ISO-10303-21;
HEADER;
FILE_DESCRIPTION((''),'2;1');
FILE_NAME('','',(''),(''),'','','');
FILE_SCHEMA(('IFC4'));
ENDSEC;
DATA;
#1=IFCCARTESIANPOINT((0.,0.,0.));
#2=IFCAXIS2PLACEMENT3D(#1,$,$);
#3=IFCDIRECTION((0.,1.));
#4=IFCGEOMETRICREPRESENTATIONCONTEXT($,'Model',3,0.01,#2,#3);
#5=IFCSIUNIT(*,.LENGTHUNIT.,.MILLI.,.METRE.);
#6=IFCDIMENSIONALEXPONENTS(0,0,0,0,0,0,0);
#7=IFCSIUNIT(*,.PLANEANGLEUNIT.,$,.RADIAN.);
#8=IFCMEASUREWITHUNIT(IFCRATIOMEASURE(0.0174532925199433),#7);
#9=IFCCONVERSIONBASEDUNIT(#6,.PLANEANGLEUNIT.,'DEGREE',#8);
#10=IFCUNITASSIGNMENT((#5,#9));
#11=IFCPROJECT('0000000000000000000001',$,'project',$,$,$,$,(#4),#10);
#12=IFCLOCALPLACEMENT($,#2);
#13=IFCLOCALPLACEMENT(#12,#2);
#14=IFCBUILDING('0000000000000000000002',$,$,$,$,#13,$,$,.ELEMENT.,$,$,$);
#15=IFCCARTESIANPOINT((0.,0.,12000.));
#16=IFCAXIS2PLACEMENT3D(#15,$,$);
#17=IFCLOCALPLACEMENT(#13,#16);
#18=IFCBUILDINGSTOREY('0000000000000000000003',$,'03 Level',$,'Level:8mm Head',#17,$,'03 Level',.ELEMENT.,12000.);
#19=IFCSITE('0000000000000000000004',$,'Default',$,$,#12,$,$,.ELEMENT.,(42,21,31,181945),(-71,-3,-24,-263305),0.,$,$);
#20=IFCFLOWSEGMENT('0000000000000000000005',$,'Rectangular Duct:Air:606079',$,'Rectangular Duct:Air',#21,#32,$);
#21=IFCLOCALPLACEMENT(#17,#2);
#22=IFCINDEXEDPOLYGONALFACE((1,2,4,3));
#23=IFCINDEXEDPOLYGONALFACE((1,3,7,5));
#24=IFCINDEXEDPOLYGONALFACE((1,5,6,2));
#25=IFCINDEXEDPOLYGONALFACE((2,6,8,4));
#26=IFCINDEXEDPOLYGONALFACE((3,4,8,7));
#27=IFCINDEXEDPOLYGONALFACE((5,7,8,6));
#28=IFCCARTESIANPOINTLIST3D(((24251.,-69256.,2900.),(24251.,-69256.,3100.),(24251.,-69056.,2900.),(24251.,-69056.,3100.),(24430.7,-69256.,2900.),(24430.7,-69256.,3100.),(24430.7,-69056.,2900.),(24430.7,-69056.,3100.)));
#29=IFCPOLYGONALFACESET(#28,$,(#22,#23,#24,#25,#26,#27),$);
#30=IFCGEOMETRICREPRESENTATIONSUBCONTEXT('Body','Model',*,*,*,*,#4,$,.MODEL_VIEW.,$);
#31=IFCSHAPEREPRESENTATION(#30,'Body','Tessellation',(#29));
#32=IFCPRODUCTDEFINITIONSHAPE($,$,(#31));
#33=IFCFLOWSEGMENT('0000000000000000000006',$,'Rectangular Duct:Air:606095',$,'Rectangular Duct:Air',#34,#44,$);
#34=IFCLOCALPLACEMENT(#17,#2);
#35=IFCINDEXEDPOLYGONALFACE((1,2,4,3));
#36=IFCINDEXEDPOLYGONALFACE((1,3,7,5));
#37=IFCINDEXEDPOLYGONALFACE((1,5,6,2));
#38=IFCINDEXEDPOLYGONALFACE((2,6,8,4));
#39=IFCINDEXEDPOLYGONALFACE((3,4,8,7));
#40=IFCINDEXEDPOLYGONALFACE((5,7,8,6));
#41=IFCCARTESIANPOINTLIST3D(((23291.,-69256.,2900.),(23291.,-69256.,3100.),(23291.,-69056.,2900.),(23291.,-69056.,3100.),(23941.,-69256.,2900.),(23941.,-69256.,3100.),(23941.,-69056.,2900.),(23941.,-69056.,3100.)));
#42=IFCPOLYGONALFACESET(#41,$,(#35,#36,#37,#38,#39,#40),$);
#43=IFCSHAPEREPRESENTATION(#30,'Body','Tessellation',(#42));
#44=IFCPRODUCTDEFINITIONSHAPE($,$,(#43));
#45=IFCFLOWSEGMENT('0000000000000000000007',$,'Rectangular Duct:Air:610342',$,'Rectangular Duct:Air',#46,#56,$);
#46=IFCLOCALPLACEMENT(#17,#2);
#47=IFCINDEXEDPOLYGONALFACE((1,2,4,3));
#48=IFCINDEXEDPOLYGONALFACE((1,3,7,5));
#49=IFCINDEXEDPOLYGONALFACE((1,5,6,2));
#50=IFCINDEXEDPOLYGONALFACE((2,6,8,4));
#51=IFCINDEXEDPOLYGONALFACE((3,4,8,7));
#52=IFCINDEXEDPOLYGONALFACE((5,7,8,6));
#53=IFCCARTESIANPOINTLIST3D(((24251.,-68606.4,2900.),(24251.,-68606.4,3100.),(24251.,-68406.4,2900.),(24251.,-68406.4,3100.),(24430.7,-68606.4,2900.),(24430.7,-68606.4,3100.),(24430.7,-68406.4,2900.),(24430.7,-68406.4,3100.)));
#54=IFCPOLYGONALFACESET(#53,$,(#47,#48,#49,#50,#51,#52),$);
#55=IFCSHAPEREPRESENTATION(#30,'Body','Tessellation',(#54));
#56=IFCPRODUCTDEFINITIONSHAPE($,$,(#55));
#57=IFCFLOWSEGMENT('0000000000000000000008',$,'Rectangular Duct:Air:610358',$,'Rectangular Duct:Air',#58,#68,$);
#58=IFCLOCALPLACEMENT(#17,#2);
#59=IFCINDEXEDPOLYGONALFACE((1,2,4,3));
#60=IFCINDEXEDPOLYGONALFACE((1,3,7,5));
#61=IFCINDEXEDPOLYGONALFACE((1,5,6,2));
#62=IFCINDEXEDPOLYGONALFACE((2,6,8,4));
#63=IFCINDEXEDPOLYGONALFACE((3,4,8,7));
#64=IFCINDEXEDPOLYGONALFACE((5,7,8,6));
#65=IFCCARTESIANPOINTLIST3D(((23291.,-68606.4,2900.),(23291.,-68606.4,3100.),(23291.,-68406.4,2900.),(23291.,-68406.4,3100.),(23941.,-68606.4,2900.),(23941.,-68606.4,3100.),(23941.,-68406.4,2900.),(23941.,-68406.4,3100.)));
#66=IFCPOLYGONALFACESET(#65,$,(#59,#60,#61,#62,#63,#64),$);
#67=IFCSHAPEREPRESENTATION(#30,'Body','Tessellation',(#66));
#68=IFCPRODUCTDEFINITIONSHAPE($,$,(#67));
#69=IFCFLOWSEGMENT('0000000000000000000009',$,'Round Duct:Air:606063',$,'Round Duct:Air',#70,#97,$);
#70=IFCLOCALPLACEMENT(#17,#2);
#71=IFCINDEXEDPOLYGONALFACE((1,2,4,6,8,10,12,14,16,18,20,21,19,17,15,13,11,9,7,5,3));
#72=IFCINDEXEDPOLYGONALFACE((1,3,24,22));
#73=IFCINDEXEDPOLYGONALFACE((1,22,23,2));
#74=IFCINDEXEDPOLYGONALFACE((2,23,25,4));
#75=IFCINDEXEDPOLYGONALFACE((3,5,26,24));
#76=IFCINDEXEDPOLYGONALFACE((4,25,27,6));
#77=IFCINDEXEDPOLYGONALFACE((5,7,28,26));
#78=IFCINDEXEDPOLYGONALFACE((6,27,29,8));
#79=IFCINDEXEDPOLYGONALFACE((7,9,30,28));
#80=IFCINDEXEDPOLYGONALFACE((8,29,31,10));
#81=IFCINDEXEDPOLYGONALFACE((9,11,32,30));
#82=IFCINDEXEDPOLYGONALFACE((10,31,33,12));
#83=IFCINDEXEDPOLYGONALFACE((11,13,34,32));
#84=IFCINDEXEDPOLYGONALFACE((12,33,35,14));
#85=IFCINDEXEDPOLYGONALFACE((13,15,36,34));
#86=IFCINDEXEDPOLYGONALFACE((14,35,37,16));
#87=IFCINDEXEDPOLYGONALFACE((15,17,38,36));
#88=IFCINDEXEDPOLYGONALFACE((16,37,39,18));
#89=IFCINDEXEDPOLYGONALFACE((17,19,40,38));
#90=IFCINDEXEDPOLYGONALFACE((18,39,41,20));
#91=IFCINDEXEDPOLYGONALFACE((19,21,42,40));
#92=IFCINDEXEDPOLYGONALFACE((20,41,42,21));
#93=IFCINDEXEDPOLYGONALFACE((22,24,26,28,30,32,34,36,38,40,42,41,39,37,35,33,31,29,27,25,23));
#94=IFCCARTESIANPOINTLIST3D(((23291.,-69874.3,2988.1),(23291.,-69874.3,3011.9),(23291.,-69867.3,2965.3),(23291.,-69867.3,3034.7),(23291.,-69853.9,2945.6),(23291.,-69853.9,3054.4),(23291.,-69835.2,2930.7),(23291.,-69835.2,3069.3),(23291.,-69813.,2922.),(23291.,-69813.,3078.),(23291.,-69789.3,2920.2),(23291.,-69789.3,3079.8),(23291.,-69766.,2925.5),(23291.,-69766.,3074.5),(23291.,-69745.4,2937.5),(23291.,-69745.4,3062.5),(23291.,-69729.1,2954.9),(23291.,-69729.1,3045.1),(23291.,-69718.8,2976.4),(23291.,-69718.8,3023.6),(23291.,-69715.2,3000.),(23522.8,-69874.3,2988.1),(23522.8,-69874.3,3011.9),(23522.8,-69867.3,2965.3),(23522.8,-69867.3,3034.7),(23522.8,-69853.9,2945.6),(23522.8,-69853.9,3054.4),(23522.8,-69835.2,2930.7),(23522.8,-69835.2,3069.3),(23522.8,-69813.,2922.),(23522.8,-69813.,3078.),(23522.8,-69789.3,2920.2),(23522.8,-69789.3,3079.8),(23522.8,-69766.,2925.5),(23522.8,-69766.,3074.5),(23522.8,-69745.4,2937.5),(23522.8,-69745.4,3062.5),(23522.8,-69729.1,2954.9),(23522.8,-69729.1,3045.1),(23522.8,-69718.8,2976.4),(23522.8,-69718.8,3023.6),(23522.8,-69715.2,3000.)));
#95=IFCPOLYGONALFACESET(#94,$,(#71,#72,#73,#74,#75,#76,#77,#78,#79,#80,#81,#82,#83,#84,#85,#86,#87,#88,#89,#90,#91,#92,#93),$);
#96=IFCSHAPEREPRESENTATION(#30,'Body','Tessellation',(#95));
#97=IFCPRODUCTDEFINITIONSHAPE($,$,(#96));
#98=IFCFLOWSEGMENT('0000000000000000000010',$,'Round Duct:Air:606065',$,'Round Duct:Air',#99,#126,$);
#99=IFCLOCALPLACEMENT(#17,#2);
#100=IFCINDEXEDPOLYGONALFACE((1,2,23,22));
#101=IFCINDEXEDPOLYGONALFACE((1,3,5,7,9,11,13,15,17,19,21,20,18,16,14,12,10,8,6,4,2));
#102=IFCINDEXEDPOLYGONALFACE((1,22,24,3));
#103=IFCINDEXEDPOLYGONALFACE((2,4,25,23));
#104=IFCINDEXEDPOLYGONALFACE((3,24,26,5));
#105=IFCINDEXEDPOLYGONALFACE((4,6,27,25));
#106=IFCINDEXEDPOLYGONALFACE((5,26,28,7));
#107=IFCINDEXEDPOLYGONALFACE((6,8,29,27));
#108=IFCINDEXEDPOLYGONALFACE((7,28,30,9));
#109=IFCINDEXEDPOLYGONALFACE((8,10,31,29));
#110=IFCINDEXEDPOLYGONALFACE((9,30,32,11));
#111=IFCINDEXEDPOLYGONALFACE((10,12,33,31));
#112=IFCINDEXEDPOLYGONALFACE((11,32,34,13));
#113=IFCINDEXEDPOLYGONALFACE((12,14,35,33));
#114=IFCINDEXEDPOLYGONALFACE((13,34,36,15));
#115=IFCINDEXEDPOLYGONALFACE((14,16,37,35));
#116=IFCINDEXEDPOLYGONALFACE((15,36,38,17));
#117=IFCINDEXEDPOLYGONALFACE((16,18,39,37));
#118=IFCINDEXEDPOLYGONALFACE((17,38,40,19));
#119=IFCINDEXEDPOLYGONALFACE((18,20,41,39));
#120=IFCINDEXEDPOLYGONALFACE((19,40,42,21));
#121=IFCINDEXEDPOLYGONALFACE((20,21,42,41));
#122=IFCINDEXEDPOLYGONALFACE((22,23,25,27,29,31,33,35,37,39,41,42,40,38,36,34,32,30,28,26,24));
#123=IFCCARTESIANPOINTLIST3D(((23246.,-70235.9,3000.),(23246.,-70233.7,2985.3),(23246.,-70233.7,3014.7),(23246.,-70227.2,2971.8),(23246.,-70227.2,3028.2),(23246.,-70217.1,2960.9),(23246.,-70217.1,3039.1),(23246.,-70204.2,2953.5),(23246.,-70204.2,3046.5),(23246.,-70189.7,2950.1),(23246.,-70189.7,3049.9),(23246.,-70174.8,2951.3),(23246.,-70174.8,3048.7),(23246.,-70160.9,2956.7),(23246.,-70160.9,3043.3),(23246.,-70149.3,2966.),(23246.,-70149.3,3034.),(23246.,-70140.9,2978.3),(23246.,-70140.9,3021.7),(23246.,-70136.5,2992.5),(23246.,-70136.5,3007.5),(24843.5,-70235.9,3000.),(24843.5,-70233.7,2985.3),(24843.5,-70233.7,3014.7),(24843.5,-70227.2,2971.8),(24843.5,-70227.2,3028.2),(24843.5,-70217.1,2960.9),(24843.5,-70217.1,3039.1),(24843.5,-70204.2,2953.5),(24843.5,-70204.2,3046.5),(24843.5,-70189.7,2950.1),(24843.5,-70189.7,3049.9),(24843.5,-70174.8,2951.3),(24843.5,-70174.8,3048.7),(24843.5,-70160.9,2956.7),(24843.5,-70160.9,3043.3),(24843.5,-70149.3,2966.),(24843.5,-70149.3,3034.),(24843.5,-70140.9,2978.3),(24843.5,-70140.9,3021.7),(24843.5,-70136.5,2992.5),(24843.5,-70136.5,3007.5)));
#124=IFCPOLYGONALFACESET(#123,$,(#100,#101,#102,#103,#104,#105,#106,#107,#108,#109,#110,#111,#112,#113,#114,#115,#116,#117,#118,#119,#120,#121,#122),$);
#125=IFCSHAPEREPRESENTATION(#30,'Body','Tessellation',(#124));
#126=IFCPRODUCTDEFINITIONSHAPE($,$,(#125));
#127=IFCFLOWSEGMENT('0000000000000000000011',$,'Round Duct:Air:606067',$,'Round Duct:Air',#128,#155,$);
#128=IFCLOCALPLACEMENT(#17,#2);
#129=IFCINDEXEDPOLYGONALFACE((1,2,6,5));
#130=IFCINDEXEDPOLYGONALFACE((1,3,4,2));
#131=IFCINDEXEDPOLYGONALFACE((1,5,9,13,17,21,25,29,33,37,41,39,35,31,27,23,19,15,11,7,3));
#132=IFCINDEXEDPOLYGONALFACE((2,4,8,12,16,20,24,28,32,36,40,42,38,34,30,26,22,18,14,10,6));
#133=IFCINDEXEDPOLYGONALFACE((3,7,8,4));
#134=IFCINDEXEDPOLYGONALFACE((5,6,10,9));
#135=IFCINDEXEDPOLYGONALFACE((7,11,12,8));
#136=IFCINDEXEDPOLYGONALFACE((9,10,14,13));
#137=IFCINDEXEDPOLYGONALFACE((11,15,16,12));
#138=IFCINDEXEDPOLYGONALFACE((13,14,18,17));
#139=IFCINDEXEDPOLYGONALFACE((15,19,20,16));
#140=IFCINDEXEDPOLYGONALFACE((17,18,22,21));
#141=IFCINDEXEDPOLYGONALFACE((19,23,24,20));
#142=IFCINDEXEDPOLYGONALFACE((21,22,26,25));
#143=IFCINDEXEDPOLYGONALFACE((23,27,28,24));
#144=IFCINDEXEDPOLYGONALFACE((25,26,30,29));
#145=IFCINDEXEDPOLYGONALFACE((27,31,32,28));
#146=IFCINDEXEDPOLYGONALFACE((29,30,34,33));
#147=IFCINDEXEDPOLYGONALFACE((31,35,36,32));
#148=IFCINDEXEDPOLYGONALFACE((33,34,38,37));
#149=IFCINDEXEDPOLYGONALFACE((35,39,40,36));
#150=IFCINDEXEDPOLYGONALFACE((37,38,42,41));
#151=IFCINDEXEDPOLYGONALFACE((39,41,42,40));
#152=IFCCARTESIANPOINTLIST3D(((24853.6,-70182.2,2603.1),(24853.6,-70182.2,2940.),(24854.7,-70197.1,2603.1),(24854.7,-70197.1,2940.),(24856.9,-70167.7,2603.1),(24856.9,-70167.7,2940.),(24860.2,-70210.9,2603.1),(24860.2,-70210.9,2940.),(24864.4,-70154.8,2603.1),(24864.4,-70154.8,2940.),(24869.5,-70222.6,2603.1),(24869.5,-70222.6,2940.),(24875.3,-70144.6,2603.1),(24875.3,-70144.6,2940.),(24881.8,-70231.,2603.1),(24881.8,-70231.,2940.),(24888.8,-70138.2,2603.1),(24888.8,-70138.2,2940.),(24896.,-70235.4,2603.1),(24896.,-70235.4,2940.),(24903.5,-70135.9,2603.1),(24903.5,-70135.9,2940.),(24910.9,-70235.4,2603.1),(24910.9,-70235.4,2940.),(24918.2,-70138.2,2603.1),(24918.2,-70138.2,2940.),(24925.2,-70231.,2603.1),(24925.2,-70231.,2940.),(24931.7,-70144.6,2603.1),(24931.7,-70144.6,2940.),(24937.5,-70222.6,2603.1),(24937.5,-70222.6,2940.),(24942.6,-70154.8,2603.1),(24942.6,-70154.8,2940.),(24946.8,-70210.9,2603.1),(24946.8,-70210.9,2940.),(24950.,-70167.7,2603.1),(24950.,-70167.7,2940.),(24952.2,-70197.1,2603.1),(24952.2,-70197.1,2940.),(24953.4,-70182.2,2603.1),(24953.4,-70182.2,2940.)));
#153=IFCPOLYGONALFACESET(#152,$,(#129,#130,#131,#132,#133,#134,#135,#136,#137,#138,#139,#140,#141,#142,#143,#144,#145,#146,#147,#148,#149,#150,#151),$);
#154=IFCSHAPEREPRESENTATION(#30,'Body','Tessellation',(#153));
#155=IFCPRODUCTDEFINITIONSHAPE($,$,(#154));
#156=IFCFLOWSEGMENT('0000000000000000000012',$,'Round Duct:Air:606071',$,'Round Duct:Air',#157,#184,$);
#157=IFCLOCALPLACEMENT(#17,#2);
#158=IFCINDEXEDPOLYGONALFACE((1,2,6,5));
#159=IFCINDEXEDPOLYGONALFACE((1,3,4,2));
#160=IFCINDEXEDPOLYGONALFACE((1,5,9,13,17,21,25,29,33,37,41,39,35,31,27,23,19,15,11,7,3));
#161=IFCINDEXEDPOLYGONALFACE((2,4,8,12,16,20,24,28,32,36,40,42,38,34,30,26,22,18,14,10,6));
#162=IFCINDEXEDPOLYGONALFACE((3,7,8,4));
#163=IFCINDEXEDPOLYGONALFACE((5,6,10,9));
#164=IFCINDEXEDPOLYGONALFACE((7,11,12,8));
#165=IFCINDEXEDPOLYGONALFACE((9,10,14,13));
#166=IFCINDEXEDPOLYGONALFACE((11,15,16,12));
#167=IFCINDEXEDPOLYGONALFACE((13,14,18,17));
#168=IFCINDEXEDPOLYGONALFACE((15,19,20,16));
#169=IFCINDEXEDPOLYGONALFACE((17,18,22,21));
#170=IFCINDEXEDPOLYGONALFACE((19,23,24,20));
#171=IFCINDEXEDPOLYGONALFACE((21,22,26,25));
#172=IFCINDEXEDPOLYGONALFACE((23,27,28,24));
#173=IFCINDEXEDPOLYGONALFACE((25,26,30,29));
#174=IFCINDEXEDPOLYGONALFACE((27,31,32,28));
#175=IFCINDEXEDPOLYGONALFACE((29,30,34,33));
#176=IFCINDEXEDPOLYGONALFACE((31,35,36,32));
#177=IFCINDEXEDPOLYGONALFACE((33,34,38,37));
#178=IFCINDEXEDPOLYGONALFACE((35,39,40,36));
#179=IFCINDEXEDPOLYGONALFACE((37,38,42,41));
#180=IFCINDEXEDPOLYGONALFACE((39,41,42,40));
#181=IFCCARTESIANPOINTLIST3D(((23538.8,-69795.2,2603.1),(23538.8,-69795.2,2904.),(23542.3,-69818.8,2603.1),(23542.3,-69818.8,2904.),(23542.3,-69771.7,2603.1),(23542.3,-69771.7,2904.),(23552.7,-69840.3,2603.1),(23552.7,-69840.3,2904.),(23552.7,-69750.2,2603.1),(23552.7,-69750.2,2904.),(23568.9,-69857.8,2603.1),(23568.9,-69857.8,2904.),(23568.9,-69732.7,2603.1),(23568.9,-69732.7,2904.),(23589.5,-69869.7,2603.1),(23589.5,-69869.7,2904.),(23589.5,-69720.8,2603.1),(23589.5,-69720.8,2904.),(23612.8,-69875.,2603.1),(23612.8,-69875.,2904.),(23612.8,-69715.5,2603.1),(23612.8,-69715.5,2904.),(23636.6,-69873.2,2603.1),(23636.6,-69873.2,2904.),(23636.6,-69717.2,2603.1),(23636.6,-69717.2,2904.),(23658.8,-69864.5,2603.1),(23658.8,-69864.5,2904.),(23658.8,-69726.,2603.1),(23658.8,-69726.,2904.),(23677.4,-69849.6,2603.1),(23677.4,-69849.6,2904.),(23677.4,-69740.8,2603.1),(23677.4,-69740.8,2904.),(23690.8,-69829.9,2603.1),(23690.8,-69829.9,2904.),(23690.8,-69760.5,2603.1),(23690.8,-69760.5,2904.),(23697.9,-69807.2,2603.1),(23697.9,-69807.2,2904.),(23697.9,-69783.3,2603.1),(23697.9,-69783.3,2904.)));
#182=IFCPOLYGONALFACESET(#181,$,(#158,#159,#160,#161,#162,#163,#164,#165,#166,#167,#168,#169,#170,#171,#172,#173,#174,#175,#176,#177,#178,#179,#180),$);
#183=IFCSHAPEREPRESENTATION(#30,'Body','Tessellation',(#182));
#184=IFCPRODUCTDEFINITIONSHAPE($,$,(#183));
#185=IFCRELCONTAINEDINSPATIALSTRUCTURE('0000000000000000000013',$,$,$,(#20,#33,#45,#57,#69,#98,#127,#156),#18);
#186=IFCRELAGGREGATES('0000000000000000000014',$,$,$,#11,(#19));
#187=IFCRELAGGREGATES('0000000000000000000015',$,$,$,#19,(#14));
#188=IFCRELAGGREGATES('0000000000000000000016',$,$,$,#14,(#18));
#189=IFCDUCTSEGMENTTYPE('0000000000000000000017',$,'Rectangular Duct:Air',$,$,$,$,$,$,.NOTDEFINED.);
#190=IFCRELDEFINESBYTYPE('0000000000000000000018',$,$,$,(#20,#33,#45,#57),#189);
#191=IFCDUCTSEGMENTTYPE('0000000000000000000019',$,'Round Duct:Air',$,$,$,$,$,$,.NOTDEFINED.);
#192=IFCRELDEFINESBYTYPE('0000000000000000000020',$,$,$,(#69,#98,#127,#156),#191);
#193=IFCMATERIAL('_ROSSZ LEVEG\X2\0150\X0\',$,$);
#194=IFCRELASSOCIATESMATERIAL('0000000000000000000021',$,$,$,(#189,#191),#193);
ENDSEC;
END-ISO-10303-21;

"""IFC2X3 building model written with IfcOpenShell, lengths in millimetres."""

from ifc_helpers import new_model, entity, si_unit, converted_unit, direction, frame, frame_2d, origin, origin_2d_with_axis, place, context, subcontext, project, spatial, rectangle, circle, extrude, material, type_object, element, save


model = new_model("IFC2X3")

# Units and contexts
model_context = context("Model", 3, precision=0.01, world=origin(), true_north=direction((0.0, 1.0)))
body_context = subcontext(model_context, "Body", "Model", "MODEL_VIEW")
ifc_project = project(units=[si_unit("LENGTHUNIT", "METRE", prefix="MILLI"), converted_unit("PLANEANGLEUNIT", "DEGREE", entity("IfcRatioMeasure", 0.0174532925199433), si_unit("PLANEANGLEUNIT", "RADIAN"), dimensions=[0, 0, 0, 0, 0, 0, 0])], contexts=[model_context])

# Site, building, storey
site_placement = place(None, origin())
site = spatial("IfcSite", under=ifc_project, at=site_placement, Name="Default", CompositionType="ELEMENT", RefLatitude=(42, 21, 31, 181945), RefLongitude=(-71, -3, -24, -263305), RefElevation=0.0)
building_placement = place(site_placement, origin())
building = spatial("IfcBuilding", under=site, at=building_placement, CompositionType="ELEMENT")
storey_placement = place(building_placement, frame((0.0, 0.0, 12000.0)))
storey = spatial("IfcBuildingStorey", under=building, at=storey_placement, Name="03 Level", ObjectType="Level:8mm Head", LongName="03 Level", CompositionType="ELEMENT", Elevation=12000.0)

# Flow segments
ifc_material = material(Name="_ROSSZ LEVEGŐ")
duct_segment_type_1 = type_object("IfcDuctSegmentType", Name="Rectangular Duct:Air", PredefinedType="NOTDEFINED", material=ifc_material)
flow_segment_1_placement = place(storey_placement, origin())
element("IfcFlowSegment", 1, at=flow_segment_1_placement, inside=storey, type_object=duct_segment_type_1, Name="Rectangular Duct:Air:606079", ObjectType="Rectangular Duct:Air", context=body_context, shape_type="SweptSolid", body=[
    extrude(rectangle(XDim=179.7, YDim=200.0, at=frame_2d((0.0, 0.0), x_axis=(1.0, 0.0))), frame((24340.8, -69156.0, 2900.0)), (0.0, 0.0, 1.0), 200.0),
])
flow_segment_2_placement = place(storey_placement, origin())
element("IfcFlowSegment", 2, at=flow_segment_2_placement, inside=storey, type_object=duct_segment_type_1, Name="Rectangular Duct:Air:606095", ObjectType="Rectangular Duct:Air", context=body_context, shape_type="SweptSolid", body=[
    extrude(rectangle(XDim=650.0, YDim=200.0, at=frame_2d((0.0, 0.0), x_axis=(1.0, 0.0))), frame((23616.0, -69156.0, 2900.0), z_axis=(0.0, 0.0, 1.0), x_axis=(-1.0, 0.0, 0.0)), (0.0, 0.0, 1.0), 200.0),
])
flow_segment_3_placement = place(storey_placement, origin())
element("IfcFlowSegment", 3, at=flow_segment_3_placement, inside=storey, type_object=duct_segment_type_1, Name="Rectangular Duct:Air:610342", ObjectType="Rectangular Duct:Air", context=body_context, shape_type="SweptSolid", body=[
    extrude(rectangle(XDim=179.7, YDim=200.0, at=frame_2d((0.0, 0.0), x_axis=(1.0, 0.0))), frame((24340.8, -68506.4, 2900.0)), (0.0, 0.0, 1.0), 200.0),
])
flow_segment_4_placement = place(storey_placement, origin())
element("IfcFlowSegment", 4, at=flow_segment_4_placement, inside=storey, type_object=duct_segment_type_1, Name="Rectangular Duct:Air:610358", ObjectType="Rectangular Duct:Air", context=body_context, shape_type="SweptSolid", body=[
    extrude(rectangle(XDim=650.0, YDim=200.0, at=frame_2d((0.0, 0.0), x_axis=(1.0, 0.0))), frame((23616.0, -68506.4, 2900.0), z_axis=(0.0, 0.0, 1.0), x_axis=(-1.0, 0.0, 0.0)), (0.0, 0.0, 1.0), 200.0),
])
duct_segment_type_2 = type_object("IfcDuctSegmentType", Name="Round Duct:Air", PredefinedType="NOTDEFINED", material=ifc_material)
flow_segment_5_placement = place(storey_placement, origin())
element("IfcFlowSegment", 5, at=flow_segment_5_placement, inside=storey, type_object=duct_segment_type_2, Name="Round Duct:Air:606063", ObjectType="Round Duct:Air", context=body_context, shape_type="SweptSolid", body=[
    extrude(circle(Radius=80.0, at=origin_2d_with_axis()), frame((23291.0, -69795.2, 3000.0), z_axis=(1.0, 0.0, 0.0), x_axis=(0.0, 1.0, 0.0)), (0.0, 0.0, 1.0), 231.8),
])
flow_segment_6_placement = place(storey_placement, origin())
element("IfcFlowSegment", 6, at=flow_segment_6_placement, inside=storey, type_object=duct_segment_type_2, Name="Round Duct:Air:606065", ObjectType="Round Duct:Air", context=body_context, shape_type="SweptSolid", body=[
    extrude(circle(Radius=50.0, at=origin_2d_with_axis()), frame((23246.0, -70185.9, 3000.0), z_axis=(1.0, 0.0, 0.0), x_axis=(0.0, -1.0, 0.0)), (0.0, 0.0, 1.0), 1597.5),
])
flow_segment_7_placement = place(storey_placement, origin())
element("IfcFlowSegment", 7, at=flow_segment_7_placement, inside=storey, type_object=duct_segment_type_2, Name="Round Duct:Air:606067", ObjectType="Round Duct:Air", context=body_context, shape_type="SweptSolid", body=[
    extrude(circle(Radius=50.0, at=origin_2d_with_axis()), frame((24903.5, -70185.9, 2603.1), z_axis=(0.0, 0.0, 1.0), x_axis=(0.0, 1.0, 0.0)), (0.0, 0.0, 1.0), 336.9),
])
flow_segment_8_placement = place(storey_placement, origin())
element("IfcFlowSegment", 8, at=flow_segment_8_placement, inside=storey, type_object=duct_segment_type_2, Name="Round Duct:Air:606071", ObjectType="Round Duct:Air", context=body_context, shape_type="SweptSolid", body=[
    extrude(circle(Radius=80.0, at=origin_2d_with_axis()), frame((23618.8, -69795.2, 2603.1), z_axis=(0.0, 0.0, 1.0), x_axis=(-1.0, 0.0, 0.0)), (0.0, 0.0, 1.0), 300.9),
])

save(model, "model.ifc")
